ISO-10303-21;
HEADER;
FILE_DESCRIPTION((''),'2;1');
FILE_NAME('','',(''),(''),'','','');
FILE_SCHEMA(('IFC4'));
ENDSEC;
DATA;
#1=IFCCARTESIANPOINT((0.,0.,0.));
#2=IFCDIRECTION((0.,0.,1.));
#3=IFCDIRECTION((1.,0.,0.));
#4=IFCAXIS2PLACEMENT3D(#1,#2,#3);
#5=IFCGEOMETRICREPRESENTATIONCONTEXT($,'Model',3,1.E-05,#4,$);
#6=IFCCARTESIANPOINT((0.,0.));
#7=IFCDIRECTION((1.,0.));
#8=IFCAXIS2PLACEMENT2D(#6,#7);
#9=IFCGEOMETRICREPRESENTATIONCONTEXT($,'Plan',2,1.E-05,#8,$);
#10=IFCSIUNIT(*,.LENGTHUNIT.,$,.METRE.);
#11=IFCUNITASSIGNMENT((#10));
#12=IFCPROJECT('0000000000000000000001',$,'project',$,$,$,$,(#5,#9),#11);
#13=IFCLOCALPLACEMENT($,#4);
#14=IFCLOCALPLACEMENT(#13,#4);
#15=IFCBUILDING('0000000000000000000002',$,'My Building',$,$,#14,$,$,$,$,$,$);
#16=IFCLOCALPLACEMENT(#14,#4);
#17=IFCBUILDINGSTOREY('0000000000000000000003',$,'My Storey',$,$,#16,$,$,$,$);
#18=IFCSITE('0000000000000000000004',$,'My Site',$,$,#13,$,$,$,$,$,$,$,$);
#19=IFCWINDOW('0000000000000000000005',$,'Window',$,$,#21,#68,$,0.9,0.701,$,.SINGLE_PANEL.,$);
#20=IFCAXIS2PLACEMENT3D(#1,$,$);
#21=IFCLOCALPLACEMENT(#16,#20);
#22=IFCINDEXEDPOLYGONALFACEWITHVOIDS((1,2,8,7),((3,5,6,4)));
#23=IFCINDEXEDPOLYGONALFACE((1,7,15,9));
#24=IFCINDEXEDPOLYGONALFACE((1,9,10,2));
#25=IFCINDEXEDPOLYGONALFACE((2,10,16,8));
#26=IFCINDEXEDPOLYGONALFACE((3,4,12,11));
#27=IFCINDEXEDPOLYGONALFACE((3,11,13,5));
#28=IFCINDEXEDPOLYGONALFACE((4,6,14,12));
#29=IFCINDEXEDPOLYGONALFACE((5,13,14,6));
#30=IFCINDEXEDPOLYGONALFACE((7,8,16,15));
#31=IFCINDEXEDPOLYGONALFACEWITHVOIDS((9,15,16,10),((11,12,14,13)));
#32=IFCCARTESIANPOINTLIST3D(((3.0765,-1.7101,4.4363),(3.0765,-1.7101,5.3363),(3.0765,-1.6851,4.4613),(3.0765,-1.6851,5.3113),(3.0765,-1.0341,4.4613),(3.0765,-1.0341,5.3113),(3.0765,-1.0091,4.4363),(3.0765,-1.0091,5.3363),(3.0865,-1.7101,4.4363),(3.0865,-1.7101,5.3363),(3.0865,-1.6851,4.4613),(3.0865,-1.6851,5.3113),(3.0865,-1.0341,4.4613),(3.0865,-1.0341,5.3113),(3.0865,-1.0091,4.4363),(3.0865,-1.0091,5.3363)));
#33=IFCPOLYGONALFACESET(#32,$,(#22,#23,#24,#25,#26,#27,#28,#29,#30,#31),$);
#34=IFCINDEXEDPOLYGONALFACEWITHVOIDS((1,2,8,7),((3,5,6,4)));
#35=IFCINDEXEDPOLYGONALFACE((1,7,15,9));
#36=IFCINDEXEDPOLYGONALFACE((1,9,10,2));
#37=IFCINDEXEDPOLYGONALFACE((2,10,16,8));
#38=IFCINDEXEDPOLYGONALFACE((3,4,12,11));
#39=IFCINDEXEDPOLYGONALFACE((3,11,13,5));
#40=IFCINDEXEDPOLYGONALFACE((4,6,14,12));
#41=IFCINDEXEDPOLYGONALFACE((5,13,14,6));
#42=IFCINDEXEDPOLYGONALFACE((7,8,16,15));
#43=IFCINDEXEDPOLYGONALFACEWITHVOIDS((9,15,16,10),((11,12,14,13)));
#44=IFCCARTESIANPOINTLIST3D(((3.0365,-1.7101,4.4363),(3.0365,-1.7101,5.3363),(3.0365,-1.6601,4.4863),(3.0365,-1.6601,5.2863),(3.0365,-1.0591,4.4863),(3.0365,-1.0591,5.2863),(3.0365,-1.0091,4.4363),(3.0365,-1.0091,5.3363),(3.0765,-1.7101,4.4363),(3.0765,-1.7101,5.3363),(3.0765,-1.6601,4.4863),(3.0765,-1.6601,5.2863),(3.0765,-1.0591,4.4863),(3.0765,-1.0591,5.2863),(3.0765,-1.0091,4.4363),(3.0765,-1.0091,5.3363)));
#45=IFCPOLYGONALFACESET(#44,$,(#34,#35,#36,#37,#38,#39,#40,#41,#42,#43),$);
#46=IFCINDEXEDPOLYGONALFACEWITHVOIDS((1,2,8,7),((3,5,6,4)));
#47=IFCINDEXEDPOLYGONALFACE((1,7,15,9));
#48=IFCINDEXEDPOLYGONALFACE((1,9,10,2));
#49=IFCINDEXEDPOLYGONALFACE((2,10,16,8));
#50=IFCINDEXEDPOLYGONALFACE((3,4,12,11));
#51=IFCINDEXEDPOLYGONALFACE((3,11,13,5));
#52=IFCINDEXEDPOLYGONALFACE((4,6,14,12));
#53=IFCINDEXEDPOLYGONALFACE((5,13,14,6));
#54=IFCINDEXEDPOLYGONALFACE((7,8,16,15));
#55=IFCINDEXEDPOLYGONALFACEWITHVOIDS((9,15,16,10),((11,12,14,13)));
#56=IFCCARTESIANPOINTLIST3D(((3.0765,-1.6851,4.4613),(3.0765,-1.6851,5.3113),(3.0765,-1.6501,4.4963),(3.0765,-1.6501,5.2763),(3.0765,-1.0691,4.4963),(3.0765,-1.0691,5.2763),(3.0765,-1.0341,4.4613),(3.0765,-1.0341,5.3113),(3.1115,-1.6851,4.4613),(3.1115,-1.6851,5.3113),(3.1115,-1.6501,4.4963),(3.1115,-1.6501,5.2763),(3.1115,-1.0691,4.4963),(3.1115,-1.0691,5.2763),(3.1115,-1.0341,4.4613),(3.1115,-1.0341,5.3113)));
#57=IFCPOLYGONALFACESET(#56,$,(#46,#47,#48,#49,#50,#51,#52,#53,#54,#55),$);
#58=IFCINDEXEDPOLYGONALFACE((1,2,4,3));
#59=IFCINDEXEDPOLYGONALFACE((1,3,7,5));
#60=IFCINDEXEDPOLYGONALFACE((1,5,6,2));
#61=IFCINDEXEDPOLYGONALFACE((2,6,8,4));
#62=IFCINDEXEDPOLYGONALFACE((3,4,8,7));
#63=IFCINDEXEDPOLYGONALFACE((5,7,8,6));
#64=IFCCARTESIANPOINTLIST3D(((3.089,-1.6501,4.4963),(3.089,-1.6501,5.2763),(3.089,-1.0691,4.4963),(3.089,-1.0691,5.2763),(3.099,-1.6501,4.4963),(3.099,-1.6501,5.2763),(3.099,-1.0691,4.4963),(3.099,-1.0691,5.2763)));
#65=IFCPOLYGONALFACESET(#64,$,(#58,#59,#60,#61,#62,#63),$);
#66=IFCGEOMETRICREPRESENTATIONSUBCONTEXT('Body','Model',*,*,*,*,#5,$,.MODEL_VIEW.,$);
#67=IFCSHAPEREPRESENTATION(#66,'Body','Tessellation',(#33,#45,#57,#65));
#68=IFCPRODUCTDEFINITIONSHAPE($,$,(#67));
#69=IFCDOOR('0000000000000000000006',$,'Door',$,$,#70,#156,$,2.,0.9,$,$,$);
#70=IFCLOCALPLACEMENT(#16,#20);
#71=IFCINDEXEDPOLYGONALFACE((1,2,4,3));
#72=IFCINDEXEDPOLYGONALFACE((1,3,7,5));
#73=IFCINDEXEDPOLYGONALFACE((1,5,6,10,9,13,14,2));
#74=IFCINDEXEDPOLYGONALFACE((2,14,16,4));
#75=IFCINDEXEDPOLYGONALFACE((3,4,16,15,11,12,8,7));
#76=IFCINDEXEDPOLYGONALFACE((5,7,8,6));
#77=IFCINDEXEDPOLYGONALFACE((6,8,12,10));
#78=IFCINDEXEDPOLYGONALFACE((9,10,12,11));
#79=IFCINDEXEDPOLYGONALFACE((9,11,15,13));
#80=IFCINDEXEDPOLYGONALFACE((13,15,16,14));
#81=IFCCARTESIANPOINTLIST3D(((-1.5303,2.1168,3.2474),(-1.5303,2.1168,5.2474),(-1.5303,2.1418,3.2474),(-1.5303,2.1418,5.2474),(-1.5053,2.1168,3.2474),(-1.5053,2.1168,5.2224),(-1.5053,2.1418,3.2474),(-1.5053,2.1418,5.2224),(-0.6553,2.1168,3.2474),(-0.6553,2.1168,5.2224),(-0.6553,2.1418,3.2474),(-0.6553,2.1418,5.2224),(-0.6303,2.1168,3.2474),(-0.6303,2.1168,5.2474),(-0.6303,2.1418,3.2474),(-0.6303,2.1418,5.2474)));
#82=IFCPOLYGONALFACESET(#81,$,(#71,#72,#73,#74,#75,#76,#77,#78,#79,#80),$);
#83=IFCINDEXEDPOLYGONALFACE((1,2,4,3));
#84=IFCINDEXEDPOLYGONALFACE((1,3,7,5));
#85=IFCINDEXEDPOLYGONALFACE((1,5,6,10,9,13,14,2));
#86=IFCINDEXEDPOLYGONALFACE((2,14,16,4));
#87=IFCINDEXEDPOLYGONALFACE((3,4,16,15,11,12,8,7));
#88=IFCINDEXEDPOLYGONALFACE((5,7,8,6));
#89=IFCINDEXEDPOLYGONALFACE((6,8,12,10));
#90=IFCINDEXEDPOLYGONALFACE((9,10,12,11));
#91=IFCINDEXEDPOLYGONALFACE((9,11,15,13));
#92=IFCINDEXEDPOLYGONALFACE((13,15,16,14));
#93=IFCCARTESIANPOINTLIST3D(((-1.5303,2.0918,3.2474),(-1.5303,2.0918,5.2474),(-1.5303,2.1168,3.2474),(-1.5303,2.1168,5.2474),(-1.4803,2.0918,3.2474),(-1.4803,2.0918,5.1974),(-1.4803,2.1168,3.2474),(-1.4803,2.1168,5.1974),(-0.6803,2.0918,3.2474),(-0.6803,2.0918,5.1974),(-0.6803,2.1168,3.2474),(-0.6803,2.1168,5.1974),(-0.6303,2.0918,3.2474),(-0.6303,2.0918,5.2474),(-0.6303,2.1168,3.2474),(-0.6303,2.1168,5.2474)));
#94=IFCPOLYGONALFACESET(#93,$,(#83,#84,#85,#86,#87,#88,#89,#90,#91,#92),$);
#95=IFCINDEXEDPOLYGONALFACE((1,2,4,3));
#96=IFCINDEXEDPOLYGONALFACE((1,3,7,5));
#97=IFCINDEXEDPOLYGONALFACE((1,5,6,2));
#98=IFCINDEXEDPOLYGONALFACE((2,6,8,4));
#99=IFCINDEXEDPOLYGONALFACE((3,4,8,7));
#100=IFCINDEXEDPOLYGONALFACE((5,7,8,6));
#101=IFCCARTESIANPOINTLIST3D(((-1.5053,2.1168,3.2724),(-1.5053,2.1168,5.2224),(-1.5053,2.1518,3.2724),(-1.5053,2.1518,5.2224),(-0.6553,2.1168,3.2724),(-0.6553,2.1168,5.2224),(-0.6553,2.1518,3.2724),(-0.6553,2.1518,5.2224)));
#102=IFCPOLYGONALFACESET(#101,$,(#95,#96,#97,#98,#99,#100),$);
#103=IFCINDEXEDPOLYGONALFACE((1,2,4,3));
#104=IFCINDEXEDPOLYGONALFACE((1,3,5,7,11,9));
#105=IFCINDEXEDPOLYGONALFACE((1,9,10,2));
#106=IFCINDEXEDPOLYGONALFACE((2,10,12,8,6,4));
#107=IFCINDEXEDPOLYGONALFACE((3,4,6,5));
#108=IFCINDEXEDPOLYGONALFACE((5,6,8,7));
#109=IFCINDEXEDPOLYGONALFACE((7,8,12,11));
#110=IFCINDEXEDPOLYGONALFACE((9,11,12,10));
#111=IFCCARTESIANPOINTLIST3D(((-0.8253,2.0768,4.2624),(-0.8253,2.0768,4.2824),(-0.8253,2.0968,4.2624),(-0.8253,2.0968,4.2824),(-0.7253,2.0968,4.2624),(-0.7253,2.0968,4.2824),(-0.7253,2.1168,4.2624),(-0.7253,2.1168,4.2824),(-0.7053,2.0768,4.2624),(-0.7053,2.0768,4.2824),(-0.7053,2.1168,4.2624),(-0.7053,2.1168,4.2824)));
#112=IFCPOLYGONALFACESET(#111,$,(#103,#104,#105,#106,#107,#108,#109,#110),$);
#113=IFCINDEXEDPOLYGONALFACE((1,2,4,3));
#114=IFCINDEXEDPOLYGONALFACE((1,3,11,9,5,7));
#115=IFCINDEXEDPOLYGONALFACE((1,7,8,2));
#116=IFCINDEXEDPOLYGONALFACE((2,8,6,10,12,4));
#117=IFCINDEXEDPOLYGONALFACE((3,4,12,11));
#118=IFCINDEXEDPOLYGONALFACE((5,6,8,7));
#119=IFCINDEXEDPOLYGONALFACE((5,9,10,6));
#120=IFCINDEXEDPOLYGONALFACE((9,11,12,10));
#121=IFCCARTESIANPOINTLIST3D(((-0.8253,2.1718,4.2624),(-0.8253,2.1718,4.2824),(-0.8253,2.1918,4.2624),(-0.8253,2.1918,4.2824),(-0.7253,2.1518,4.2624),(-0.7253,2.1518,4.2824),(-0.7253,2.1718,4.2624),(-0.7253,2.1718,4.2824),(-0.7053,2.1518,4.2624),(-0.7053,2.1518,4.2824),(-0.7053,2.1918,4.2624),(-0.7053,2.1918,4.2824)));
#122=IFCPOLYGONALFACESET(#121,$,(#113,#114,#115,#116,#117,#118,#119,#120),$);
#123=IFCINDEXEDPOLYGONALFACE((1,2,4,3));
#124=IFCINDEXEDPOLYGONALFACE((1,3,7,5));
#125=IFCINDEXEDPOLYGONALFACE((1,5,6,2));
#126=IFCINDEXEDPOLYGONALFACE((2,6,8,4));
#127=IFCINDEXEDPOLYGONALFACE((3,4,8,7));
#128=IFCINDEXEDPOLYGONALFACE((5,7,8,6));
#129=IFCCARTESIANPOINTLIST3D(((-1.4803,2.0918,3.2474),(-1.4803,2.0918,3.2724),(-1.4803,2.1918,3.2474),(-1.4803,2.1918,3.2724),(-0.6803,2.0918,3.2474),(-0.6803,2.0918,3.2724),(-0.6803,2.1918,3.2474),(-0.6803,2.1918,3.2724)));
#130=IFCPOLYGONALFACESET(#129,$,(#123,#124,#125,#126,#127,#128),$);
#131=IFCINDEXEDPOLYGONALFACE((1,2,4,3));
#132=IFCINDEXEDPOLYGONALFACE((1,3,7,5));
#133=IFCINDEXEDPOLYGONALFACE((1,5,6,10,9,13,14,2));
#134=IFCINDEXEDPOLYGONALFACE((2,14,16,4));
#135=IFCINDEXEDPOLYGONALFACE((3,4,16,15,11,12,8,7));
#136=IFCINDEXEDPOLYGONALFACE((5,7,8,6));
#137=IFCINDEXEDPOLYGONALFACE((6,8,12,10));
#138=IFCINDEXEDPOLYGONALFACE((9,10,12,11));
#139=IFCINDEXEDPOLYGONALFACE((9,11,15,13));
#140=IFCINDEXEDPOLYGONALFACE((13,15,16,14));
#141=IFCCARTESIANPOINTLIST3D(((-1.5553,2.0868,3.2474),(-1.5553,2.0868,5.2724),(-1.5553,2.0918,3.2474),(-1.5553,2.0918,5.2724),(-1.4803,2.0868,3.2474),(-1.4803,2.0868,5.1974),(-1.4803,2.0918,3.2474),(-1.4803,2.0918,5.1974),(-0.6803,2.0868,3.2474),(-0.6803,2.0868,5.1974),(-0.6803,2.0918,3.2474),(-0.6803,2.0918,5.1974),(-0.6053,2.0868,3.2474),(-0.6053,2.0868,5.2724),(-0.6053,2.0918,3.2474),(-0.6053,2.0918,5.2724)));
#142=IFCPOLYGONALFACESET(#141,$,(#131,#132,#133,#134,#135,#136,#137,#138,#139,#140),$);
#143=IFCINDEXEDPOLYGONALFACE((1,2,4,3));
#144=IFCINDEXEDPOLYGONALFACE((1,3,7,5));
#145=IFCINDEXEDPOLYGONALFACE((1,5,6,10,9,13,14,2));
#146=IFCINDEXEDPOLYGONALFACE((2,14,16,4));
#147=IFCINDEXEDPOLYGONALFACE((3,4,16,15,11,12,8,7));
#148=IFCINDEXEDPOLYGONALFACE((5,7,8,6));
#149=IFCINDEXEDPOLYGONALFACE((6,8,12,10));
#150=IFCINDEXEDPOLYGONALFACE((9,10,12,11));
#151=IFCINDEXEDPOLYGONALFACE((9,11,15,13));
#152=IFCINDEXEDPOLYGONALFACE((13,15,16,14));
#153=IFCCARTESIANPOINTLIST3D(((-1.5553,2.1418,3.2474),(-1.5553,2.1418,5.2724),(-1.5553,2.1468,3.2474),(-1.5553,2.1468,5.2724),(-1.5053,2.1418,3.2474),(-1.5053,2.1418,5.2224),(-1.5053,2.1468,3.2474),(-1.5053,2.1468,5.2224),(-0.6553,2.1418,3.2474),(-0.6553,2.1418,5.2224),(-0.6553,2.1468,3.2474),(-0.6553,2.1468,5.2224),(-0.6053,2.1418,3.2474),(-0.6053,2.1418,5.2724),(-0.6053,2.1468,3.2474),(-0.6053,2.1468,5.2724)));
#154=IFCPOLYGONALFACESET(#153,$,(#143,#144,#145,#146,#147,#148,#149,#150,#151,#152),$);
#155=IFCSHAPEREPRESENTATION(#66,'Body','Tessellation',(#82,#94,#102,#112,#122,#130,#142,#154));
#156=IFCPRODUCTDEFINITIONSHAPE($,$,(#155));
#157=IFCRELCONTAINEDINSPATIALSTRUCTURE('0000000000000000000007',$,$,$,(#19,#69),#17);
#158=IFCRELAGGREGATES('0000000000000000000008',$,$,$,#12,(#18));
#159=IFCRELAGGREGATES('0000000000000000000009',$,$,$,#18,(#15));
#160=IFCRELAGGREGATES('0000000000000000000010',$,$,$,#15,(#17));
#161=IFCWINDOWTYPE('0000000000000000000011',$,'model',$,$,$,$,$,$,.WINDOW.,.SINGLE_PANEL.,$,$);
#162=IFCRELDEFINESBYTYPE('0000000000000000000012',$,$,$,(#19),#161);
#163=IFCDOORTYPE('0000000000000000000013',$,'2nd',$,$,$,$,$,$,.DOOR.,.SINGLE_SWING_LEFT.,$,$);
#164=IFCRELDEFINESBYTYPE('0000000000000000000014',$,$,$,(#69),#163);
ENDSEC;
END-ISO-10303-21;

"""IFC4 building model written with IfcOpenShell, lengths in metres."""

from ifc_helpers import new_model, entity, si_unit, frame, origin_with_axes, origin_2d_with_axis, place, context, subcontext, project, spatial, line, indexed_curve, outline, extrude, shape, source, transform, mapped, type_object, type_shapes, element, save


model = new_model("IFC4")

# Units and contexts
model_context = context("Model", 3, precision=1e-05, world=origin_with_axes())
plan_context = context("Plan", 2, precision=1e-05, world=origin_2d_with_axis())
body_context_1 = subcontext(model_context, "Body", "Model", "MODEL_VIEW")
body_context_2 = subcontext(plan_context, "Body", "Plan", "PLAN_VIEW")
ifc_project = project(units=[si_unit("LENGTHUNIT", "METRE")], contexts=[model_context, plan_context])

# Site, building, storey
site_placement = place(None, origin_with_axes())
site = spatial("IfcSite", under=ifc_project, at=site_placement, Name="My Site")
building_placement = place(site_placement, origin_with_axes())
building = spatial("IfcBuilding", under=site, at=building_placement, Name="My Building")
storey_placement = place(building_placement, origin_with_axes())
storey = spatial("IfcBuildingStorey", under=building, at=storey_placement, Name="My Storey")

# Window
window_type_1 = type_object("IfcWindowType", Name="model", PartitioningType="SINGLE_PANEL", PredefinedType="WINDOW")
shared_shape_1 = source(origin_with_axes(), body_context_1, "Body", "SweptSolid", [
    extrude(outline(indexed_curve([(0.0, 0.0), (0.701, 0.0), (0.701, 0.9), (0.0, 0.9)], segments=[line(1, 2, 3, 4, 1)]), holes=[indexed_curve([(0.025, 0.025), (0.676, 0.025), (0.676, 0.875), (0.025, 0.875)], segments=[line(1, 2, 3, 4, 1)])]), frame((0.0, 0.09, 0.0), z_axis=(0.0, -1.0, 0.0), x_axis=(1.0, 0.0, 0.0)), (0.0, 0.0, -1.0), 0.01),
    extrude(outline(indexed_curve([(0.0, 0.0), (0.701, 0.0), (0.701, 0.9), (0.0, 0.9)], segments=[line(1, 2, 3, 4, 1)]), holes=[indexed_curve([(0.05, 0.05), (0.651, 0.05), (0.651, 0.85), (0.05, 0.85)], segments=[line(1, 2, 3, 4, 1)])]), frame((0.0, 0.05, 0.0), z_axis=(0.0, -1.0, 0.0), x_axis=(1.0, 0.0, 0.0)), (0.0, 0.0, -1.0), 0.04),
    extrude(outline(indexed_curve([(0.0, 0.0), (0.651, 0.0), (0.651, 0.85), (0.0, 0.85)], segments=[line(1, 2, 3, 4, 1)]), holes=[indexed_curve([(0.035, 0.035), (0.616, 0.035), (0.616, 0.815), (0.035, 0.815)], segments=[line(1, 2, 3, 4, 1)])]), frame((0.025, 0.09, 0.025), z_axis=(0.0, -1.0, 0.0), x_axis=(1.0, 0.0, 0.0)), (0.0, 0.0, -1.0), 0.035),
    extrude(outline(indexed_curve([(0.035, 0.035), (0.616, 0.035), (0.616, 0.815), (0.035, 0.815)], segments=[line(1, 2, 3, 4, 1)])), frame((0.025, 0.1025, 0.025), z_axis=(0.0, -1.0, 0.0), x_axis=(1.0, 0.0, 0.0)), (0.0, 0.0, -1.0), 0.01),
])
shared_shape_2 = source(origin_with_axes(), body_context_2, "Body", "Curve2D", [
    entity("IfcIndexedPolyCurve", entity("IfcCartesianPointList2D", [[0.05, 0.05], [0.651, 0.05]])),
    entity("IfcIndexedPolyCurve", entity("IfcCartesianPointList2D", [[0.0, 0.1], [0.025, 0.1], [0.025, 0.09], [0.05, 0.09], [0.05, 0.05], [0.0, 0.05]]), [entity("IfcLineIndex", [1, 2, 3, 4, 5, 6, 1])]),
    entity("IfcIndexedPolyCurve", entity("IfcCartesianPointList2D", [[0.701, 0.1], [0.676, 0.1], [0.676, 0.09], [0.651, 0.09], [0.651, 0.05], [0.701, 0.05]]), [entity("IfcLineIndex", [1, 2, 3, 4, 5, 6, 1])]),
    entity("IfcIndexedPolyCurve", entity("IfcCartesianPointList2D", [[0.025, 0.09], [0.06, 0.09], [0.06, 0.125], [0.025, 0.125]]), [entity("IfcLineIndex", [1, 2, 3, 4, 1])]),
    entity("IfcIndexedPolyCurve", entity("IfcCartesianPointList2D", [[0.676, 0.09], [0.641, 0.09], [0.641, 0.125], [0.676, 0.125]]), [entity("IfcLineIndex", [1, 2, 3, 4, 1])]),
    entity("IfcIndexedPolyCurve", entity("IfcCartesianPointList2D", [[0.06, 0.09], [0.641, 0.09]])),
    entity("IfcIndexedPolyCurve", entity("IfcCartesianPointList2D", [[0.06, 0.125], [0.641, 0.125]])),
    entity("IfcIndexedPolyCurve", entity("IfcCartesianPointList2D", [[0.06, 0.1075], [0.641, 0.1075]])),
])
type_shapes(window_type_1, [shared_shape_1, shared_shape_2])
for number, where, z_axis, x_axis, name in (
    (1, (2.9865, -1.0091, 4.4363), (0.0, 0.0, 1.0), (0.0, -1.0, 0.0), "Window"),
):
    element("IfcWindow", number, at=place(storey_placement, frame(where, z_axis=z_axis, x_axis=x_axis)), inside=storey, type_object=window_type_1, Name=name, OverallHeight=0.9, OverallWidth=0.701, PartitioningType="SINGLE_PANEL", shapes=[
        shape(body_context_1, "Body", "MappedRepresentation", [mapped(shared_shape_1, transform((0.0, 0.0, 0.0), x_axis=(1.0, 0.0, 0.0), y_axis=(0.0, 1.0, 0.0), z_axis=(0.0, 0.0, 1.0), scale=1.0))]),
        shape(body_context_2, "Body", "MappedRepresentation", [mapped(shared_shape_2, transform((0.0, 0.0, 0.0), x_axis=(1.0, 0.0, 0.0), y_axis=(0.0, 1.0, 0.0), z_axis=(0.0, 0.0, 1.0), scale=1.0))]),
    ])

# Door
door_type_1 = type_object("IfcDoorType", Name="2nd", OperationType="SINGLE_SWING_LEFT", PredefinedType="DOOR")
shared_shape_3 = source(origin_with_axes(), body_context_1, "Body", "SweptSolid", [
    extrude(outline(indexed_curve([(0.0, 0.0), (0.0, 2.0), (0.9, 2.0), (0.9, 0.0), (0.875, 0.0), (0.875, 1.975), (0.025, 1.975), (0.025, 0.0)], segments=[line(1, 2, 3, 4, 5, 6, 7, 8, 1)])), frame((0.0, 0.025, 0.0), z_axis=(0.0, -1.0, 0.0), x_axis=(1.0, 0.0, 0.0)), (0.0, 0.0, -1.0), 0.025),
    extrude(outline(indexed_curve([(0.0, 0.0), (0.0, 2.0), (0.9, 2.0), (0.9, 0.0), (0.85, 0.0), (0.85, 1.95), (0.05, 1.95), (0.05, 0.0)], segments=[line(1, 2, 3, 4, 5, 6, 7, 8, 1)])), frame((0.0, 0.0, 0.0), z_axis=(0.0, -1.0, 0.0), x_axis=(1.0, 0.0, 0.0)), (0.0, 0.0, -1.0), 0.025),
    extrude(outline(indexed_curve([(0.0, 0.0), (0.85, 0.0), (0.85, 0.035), (0.0, 0.035)], segments=[line(1, 2, 3, 4, 1)])), frame((0.025, 0.025, 0.025), z_axis=(0.0, 0.0, 1.0), x_axis=(1.0, 0.0, 0.0)), (0.0, 0.0, 1.0), 1.95),
    extrude(outline(indexed_curve([(0.0, 0.0), (0.0, -0.04), (-0.12, -0.04), (-0.12, -0.02), (-0.02, -0.02), (-0.02, 0.0)], segments=[line(1, 2, 3, 4, 5, 6, 1)])), frame((0.825, 0.025, 1.015), z_axis=(0.0, 0.0, 1.0), x_axis=(1.0, 0.0, 0.0)), (0.0, 0.0, 1.0), 0.02),
    extrude(outline(indexed_curve([(0.0, 0.0), (0.0, 0.04), (-0.12, 0.04), (-0.12, 0.02), (-0.02, 0.02), (-0.02, 0.0)], segments=[line(1, 2, 3, 4, 5, 6, 1)])), frame((0.825, 0.06, 1.015), z_axis=(0.0, 0.0, 1.0), x_axis=(1.0, 0.0, 0.0)), (0.0, 0.0, 1.0), 0.02),
    extrude(outline(indexed_curve([(0.0, 0.0), (0.8, 0.0), (0.8, 0.1), (0.0, 0.1)], segments=[line(1, 2, 3, 4, 1)])), frame((0.05, 0.0, 0.0), z_axis=(0.0, 0.0, 1.0), x_axis=(1.0, 0.0, 0.0)), (0.0, 0.0, 1.0), 0.025),
    extrude(outline(indexed_curve([(0.0, 0.0), (0.0, 2.025), (0.95, 2.025), (0.95, 0.0), (0.875, 0.0), (0.875, 1.95), (0.075, 1.95), (0.075, 0.0)], segments=[line(1, 2, 3, 4, 5, 6, 7, 8, 1)])), frame((-0.025, -0.005, 0.0), z_axis=(0.0, -1.0, 0.0), x_axis=(1.0, 0.0, 0.0)), (0.0, 0.0, -1.0), 0.005),
    extrude(outline(indexed_curve([(0.0, 0.0), (0.0, 2.025), (0.95, 2.025), (0.95, 0.0), (0.9, 0.0), (0.9, 1.975), (0.05, 1.975), (0.05, 0.0)], segments=[line(1, 2, 3, 4, 5, 6, 7, 8, 1)])), frame((-0.025, 0.05, 0.0), z_axis=(0.0, -1.0, 0.0), x_axis=(1.0, 0.0, 0.0)), (0.0, 0.0, -1.0), 0.005),
])
shared_shape_4 = source(origin_with_axes(), body_context_2, "Body", "Curve2D", [
    entity("IfcIndexedPolyCurve", entity("IfcCartesianPointList2D", [[0.0, 0.0], [0.0, 0.05], [0.025, 0.05], [0.025, 0.025], [0.05, 0.025], [0.05, 0.0]]), [entity("IfcLineIndex", [1, 2, 3, 4, 5, 6, 1])]),
    entity("IfcIndexedPolyCurve", entity("IfcCartesianPointList2D", [[0.9, 0.0], [0.9, 0.05], [0.875, 0.05], [0.875, 0.025], [0.85, 0.025], [0.85, 0.0]]), [entity("IfcLineIndex", [1, 2, 3, 4, 5, 6, 1])]),
    entity("IfcTrimmedCurve", entity("IfcEllipse", entity("IfcAxis2Placement2D", entity("IfcCartesianPoint", [0.06, 0.05]), entity("IfcDirection", [1.0, 0.0])), 0.815, 0.85), [entity("IfcCartesianPoint", [0.875, 0.05])], [entity("IfcCartesianPoint", [0.06, 0.9])], True, "CARTESIAN"),
    entity("IfcIndexedPolyCurve", entity("IfcCartesianPointList2D", [[0.025, 0.05], [0.06, 0.05], [0.06, 0.9], [0.025, 0.9]]), [entity("IfcLineIndex", [1, 2, 3, 4, 1])]),
])
type_shapes(door_type_1, [shared_shape_3, shared_shape_4])
door_1_placement = place(storey_placement, frame((-1.5303, 2.0918, 3.2474), z_axis=(0.0, 0.0, 1.0), x_axis=(1.0, 0.0, 0.0)))
element("IfcDoor", 2, at=door_1_placement, inside=storey, type_object=door_type_1, Name="Door", OverallHeight=2.0, OverallWidth=0.9, shapes=[
    shape(body_context_1, "Body", "MappedRepresentation", [mapped(shared_shape_3, transform((0.0, 0.0, 0.0), x_axis=(1.0, 0.0, 0.0), y_axis=(0.0, 1.0, 0.0), z_axis=(0.0, 0.0, 1.0), scale=1.0))]),
    shape(body_context_2, "Body", "MappedRepresentation", [mapped(shared_shape_4, transform((0.0, 0.0, 0.0), x_axis=(1.0, 0.0, 0.0), y_axis=(0.0, 1.0, 0.0), z_axis=(0.0, 0.0, 1.0), scale=1.0))]),
])

save(model, "model.ifc")
